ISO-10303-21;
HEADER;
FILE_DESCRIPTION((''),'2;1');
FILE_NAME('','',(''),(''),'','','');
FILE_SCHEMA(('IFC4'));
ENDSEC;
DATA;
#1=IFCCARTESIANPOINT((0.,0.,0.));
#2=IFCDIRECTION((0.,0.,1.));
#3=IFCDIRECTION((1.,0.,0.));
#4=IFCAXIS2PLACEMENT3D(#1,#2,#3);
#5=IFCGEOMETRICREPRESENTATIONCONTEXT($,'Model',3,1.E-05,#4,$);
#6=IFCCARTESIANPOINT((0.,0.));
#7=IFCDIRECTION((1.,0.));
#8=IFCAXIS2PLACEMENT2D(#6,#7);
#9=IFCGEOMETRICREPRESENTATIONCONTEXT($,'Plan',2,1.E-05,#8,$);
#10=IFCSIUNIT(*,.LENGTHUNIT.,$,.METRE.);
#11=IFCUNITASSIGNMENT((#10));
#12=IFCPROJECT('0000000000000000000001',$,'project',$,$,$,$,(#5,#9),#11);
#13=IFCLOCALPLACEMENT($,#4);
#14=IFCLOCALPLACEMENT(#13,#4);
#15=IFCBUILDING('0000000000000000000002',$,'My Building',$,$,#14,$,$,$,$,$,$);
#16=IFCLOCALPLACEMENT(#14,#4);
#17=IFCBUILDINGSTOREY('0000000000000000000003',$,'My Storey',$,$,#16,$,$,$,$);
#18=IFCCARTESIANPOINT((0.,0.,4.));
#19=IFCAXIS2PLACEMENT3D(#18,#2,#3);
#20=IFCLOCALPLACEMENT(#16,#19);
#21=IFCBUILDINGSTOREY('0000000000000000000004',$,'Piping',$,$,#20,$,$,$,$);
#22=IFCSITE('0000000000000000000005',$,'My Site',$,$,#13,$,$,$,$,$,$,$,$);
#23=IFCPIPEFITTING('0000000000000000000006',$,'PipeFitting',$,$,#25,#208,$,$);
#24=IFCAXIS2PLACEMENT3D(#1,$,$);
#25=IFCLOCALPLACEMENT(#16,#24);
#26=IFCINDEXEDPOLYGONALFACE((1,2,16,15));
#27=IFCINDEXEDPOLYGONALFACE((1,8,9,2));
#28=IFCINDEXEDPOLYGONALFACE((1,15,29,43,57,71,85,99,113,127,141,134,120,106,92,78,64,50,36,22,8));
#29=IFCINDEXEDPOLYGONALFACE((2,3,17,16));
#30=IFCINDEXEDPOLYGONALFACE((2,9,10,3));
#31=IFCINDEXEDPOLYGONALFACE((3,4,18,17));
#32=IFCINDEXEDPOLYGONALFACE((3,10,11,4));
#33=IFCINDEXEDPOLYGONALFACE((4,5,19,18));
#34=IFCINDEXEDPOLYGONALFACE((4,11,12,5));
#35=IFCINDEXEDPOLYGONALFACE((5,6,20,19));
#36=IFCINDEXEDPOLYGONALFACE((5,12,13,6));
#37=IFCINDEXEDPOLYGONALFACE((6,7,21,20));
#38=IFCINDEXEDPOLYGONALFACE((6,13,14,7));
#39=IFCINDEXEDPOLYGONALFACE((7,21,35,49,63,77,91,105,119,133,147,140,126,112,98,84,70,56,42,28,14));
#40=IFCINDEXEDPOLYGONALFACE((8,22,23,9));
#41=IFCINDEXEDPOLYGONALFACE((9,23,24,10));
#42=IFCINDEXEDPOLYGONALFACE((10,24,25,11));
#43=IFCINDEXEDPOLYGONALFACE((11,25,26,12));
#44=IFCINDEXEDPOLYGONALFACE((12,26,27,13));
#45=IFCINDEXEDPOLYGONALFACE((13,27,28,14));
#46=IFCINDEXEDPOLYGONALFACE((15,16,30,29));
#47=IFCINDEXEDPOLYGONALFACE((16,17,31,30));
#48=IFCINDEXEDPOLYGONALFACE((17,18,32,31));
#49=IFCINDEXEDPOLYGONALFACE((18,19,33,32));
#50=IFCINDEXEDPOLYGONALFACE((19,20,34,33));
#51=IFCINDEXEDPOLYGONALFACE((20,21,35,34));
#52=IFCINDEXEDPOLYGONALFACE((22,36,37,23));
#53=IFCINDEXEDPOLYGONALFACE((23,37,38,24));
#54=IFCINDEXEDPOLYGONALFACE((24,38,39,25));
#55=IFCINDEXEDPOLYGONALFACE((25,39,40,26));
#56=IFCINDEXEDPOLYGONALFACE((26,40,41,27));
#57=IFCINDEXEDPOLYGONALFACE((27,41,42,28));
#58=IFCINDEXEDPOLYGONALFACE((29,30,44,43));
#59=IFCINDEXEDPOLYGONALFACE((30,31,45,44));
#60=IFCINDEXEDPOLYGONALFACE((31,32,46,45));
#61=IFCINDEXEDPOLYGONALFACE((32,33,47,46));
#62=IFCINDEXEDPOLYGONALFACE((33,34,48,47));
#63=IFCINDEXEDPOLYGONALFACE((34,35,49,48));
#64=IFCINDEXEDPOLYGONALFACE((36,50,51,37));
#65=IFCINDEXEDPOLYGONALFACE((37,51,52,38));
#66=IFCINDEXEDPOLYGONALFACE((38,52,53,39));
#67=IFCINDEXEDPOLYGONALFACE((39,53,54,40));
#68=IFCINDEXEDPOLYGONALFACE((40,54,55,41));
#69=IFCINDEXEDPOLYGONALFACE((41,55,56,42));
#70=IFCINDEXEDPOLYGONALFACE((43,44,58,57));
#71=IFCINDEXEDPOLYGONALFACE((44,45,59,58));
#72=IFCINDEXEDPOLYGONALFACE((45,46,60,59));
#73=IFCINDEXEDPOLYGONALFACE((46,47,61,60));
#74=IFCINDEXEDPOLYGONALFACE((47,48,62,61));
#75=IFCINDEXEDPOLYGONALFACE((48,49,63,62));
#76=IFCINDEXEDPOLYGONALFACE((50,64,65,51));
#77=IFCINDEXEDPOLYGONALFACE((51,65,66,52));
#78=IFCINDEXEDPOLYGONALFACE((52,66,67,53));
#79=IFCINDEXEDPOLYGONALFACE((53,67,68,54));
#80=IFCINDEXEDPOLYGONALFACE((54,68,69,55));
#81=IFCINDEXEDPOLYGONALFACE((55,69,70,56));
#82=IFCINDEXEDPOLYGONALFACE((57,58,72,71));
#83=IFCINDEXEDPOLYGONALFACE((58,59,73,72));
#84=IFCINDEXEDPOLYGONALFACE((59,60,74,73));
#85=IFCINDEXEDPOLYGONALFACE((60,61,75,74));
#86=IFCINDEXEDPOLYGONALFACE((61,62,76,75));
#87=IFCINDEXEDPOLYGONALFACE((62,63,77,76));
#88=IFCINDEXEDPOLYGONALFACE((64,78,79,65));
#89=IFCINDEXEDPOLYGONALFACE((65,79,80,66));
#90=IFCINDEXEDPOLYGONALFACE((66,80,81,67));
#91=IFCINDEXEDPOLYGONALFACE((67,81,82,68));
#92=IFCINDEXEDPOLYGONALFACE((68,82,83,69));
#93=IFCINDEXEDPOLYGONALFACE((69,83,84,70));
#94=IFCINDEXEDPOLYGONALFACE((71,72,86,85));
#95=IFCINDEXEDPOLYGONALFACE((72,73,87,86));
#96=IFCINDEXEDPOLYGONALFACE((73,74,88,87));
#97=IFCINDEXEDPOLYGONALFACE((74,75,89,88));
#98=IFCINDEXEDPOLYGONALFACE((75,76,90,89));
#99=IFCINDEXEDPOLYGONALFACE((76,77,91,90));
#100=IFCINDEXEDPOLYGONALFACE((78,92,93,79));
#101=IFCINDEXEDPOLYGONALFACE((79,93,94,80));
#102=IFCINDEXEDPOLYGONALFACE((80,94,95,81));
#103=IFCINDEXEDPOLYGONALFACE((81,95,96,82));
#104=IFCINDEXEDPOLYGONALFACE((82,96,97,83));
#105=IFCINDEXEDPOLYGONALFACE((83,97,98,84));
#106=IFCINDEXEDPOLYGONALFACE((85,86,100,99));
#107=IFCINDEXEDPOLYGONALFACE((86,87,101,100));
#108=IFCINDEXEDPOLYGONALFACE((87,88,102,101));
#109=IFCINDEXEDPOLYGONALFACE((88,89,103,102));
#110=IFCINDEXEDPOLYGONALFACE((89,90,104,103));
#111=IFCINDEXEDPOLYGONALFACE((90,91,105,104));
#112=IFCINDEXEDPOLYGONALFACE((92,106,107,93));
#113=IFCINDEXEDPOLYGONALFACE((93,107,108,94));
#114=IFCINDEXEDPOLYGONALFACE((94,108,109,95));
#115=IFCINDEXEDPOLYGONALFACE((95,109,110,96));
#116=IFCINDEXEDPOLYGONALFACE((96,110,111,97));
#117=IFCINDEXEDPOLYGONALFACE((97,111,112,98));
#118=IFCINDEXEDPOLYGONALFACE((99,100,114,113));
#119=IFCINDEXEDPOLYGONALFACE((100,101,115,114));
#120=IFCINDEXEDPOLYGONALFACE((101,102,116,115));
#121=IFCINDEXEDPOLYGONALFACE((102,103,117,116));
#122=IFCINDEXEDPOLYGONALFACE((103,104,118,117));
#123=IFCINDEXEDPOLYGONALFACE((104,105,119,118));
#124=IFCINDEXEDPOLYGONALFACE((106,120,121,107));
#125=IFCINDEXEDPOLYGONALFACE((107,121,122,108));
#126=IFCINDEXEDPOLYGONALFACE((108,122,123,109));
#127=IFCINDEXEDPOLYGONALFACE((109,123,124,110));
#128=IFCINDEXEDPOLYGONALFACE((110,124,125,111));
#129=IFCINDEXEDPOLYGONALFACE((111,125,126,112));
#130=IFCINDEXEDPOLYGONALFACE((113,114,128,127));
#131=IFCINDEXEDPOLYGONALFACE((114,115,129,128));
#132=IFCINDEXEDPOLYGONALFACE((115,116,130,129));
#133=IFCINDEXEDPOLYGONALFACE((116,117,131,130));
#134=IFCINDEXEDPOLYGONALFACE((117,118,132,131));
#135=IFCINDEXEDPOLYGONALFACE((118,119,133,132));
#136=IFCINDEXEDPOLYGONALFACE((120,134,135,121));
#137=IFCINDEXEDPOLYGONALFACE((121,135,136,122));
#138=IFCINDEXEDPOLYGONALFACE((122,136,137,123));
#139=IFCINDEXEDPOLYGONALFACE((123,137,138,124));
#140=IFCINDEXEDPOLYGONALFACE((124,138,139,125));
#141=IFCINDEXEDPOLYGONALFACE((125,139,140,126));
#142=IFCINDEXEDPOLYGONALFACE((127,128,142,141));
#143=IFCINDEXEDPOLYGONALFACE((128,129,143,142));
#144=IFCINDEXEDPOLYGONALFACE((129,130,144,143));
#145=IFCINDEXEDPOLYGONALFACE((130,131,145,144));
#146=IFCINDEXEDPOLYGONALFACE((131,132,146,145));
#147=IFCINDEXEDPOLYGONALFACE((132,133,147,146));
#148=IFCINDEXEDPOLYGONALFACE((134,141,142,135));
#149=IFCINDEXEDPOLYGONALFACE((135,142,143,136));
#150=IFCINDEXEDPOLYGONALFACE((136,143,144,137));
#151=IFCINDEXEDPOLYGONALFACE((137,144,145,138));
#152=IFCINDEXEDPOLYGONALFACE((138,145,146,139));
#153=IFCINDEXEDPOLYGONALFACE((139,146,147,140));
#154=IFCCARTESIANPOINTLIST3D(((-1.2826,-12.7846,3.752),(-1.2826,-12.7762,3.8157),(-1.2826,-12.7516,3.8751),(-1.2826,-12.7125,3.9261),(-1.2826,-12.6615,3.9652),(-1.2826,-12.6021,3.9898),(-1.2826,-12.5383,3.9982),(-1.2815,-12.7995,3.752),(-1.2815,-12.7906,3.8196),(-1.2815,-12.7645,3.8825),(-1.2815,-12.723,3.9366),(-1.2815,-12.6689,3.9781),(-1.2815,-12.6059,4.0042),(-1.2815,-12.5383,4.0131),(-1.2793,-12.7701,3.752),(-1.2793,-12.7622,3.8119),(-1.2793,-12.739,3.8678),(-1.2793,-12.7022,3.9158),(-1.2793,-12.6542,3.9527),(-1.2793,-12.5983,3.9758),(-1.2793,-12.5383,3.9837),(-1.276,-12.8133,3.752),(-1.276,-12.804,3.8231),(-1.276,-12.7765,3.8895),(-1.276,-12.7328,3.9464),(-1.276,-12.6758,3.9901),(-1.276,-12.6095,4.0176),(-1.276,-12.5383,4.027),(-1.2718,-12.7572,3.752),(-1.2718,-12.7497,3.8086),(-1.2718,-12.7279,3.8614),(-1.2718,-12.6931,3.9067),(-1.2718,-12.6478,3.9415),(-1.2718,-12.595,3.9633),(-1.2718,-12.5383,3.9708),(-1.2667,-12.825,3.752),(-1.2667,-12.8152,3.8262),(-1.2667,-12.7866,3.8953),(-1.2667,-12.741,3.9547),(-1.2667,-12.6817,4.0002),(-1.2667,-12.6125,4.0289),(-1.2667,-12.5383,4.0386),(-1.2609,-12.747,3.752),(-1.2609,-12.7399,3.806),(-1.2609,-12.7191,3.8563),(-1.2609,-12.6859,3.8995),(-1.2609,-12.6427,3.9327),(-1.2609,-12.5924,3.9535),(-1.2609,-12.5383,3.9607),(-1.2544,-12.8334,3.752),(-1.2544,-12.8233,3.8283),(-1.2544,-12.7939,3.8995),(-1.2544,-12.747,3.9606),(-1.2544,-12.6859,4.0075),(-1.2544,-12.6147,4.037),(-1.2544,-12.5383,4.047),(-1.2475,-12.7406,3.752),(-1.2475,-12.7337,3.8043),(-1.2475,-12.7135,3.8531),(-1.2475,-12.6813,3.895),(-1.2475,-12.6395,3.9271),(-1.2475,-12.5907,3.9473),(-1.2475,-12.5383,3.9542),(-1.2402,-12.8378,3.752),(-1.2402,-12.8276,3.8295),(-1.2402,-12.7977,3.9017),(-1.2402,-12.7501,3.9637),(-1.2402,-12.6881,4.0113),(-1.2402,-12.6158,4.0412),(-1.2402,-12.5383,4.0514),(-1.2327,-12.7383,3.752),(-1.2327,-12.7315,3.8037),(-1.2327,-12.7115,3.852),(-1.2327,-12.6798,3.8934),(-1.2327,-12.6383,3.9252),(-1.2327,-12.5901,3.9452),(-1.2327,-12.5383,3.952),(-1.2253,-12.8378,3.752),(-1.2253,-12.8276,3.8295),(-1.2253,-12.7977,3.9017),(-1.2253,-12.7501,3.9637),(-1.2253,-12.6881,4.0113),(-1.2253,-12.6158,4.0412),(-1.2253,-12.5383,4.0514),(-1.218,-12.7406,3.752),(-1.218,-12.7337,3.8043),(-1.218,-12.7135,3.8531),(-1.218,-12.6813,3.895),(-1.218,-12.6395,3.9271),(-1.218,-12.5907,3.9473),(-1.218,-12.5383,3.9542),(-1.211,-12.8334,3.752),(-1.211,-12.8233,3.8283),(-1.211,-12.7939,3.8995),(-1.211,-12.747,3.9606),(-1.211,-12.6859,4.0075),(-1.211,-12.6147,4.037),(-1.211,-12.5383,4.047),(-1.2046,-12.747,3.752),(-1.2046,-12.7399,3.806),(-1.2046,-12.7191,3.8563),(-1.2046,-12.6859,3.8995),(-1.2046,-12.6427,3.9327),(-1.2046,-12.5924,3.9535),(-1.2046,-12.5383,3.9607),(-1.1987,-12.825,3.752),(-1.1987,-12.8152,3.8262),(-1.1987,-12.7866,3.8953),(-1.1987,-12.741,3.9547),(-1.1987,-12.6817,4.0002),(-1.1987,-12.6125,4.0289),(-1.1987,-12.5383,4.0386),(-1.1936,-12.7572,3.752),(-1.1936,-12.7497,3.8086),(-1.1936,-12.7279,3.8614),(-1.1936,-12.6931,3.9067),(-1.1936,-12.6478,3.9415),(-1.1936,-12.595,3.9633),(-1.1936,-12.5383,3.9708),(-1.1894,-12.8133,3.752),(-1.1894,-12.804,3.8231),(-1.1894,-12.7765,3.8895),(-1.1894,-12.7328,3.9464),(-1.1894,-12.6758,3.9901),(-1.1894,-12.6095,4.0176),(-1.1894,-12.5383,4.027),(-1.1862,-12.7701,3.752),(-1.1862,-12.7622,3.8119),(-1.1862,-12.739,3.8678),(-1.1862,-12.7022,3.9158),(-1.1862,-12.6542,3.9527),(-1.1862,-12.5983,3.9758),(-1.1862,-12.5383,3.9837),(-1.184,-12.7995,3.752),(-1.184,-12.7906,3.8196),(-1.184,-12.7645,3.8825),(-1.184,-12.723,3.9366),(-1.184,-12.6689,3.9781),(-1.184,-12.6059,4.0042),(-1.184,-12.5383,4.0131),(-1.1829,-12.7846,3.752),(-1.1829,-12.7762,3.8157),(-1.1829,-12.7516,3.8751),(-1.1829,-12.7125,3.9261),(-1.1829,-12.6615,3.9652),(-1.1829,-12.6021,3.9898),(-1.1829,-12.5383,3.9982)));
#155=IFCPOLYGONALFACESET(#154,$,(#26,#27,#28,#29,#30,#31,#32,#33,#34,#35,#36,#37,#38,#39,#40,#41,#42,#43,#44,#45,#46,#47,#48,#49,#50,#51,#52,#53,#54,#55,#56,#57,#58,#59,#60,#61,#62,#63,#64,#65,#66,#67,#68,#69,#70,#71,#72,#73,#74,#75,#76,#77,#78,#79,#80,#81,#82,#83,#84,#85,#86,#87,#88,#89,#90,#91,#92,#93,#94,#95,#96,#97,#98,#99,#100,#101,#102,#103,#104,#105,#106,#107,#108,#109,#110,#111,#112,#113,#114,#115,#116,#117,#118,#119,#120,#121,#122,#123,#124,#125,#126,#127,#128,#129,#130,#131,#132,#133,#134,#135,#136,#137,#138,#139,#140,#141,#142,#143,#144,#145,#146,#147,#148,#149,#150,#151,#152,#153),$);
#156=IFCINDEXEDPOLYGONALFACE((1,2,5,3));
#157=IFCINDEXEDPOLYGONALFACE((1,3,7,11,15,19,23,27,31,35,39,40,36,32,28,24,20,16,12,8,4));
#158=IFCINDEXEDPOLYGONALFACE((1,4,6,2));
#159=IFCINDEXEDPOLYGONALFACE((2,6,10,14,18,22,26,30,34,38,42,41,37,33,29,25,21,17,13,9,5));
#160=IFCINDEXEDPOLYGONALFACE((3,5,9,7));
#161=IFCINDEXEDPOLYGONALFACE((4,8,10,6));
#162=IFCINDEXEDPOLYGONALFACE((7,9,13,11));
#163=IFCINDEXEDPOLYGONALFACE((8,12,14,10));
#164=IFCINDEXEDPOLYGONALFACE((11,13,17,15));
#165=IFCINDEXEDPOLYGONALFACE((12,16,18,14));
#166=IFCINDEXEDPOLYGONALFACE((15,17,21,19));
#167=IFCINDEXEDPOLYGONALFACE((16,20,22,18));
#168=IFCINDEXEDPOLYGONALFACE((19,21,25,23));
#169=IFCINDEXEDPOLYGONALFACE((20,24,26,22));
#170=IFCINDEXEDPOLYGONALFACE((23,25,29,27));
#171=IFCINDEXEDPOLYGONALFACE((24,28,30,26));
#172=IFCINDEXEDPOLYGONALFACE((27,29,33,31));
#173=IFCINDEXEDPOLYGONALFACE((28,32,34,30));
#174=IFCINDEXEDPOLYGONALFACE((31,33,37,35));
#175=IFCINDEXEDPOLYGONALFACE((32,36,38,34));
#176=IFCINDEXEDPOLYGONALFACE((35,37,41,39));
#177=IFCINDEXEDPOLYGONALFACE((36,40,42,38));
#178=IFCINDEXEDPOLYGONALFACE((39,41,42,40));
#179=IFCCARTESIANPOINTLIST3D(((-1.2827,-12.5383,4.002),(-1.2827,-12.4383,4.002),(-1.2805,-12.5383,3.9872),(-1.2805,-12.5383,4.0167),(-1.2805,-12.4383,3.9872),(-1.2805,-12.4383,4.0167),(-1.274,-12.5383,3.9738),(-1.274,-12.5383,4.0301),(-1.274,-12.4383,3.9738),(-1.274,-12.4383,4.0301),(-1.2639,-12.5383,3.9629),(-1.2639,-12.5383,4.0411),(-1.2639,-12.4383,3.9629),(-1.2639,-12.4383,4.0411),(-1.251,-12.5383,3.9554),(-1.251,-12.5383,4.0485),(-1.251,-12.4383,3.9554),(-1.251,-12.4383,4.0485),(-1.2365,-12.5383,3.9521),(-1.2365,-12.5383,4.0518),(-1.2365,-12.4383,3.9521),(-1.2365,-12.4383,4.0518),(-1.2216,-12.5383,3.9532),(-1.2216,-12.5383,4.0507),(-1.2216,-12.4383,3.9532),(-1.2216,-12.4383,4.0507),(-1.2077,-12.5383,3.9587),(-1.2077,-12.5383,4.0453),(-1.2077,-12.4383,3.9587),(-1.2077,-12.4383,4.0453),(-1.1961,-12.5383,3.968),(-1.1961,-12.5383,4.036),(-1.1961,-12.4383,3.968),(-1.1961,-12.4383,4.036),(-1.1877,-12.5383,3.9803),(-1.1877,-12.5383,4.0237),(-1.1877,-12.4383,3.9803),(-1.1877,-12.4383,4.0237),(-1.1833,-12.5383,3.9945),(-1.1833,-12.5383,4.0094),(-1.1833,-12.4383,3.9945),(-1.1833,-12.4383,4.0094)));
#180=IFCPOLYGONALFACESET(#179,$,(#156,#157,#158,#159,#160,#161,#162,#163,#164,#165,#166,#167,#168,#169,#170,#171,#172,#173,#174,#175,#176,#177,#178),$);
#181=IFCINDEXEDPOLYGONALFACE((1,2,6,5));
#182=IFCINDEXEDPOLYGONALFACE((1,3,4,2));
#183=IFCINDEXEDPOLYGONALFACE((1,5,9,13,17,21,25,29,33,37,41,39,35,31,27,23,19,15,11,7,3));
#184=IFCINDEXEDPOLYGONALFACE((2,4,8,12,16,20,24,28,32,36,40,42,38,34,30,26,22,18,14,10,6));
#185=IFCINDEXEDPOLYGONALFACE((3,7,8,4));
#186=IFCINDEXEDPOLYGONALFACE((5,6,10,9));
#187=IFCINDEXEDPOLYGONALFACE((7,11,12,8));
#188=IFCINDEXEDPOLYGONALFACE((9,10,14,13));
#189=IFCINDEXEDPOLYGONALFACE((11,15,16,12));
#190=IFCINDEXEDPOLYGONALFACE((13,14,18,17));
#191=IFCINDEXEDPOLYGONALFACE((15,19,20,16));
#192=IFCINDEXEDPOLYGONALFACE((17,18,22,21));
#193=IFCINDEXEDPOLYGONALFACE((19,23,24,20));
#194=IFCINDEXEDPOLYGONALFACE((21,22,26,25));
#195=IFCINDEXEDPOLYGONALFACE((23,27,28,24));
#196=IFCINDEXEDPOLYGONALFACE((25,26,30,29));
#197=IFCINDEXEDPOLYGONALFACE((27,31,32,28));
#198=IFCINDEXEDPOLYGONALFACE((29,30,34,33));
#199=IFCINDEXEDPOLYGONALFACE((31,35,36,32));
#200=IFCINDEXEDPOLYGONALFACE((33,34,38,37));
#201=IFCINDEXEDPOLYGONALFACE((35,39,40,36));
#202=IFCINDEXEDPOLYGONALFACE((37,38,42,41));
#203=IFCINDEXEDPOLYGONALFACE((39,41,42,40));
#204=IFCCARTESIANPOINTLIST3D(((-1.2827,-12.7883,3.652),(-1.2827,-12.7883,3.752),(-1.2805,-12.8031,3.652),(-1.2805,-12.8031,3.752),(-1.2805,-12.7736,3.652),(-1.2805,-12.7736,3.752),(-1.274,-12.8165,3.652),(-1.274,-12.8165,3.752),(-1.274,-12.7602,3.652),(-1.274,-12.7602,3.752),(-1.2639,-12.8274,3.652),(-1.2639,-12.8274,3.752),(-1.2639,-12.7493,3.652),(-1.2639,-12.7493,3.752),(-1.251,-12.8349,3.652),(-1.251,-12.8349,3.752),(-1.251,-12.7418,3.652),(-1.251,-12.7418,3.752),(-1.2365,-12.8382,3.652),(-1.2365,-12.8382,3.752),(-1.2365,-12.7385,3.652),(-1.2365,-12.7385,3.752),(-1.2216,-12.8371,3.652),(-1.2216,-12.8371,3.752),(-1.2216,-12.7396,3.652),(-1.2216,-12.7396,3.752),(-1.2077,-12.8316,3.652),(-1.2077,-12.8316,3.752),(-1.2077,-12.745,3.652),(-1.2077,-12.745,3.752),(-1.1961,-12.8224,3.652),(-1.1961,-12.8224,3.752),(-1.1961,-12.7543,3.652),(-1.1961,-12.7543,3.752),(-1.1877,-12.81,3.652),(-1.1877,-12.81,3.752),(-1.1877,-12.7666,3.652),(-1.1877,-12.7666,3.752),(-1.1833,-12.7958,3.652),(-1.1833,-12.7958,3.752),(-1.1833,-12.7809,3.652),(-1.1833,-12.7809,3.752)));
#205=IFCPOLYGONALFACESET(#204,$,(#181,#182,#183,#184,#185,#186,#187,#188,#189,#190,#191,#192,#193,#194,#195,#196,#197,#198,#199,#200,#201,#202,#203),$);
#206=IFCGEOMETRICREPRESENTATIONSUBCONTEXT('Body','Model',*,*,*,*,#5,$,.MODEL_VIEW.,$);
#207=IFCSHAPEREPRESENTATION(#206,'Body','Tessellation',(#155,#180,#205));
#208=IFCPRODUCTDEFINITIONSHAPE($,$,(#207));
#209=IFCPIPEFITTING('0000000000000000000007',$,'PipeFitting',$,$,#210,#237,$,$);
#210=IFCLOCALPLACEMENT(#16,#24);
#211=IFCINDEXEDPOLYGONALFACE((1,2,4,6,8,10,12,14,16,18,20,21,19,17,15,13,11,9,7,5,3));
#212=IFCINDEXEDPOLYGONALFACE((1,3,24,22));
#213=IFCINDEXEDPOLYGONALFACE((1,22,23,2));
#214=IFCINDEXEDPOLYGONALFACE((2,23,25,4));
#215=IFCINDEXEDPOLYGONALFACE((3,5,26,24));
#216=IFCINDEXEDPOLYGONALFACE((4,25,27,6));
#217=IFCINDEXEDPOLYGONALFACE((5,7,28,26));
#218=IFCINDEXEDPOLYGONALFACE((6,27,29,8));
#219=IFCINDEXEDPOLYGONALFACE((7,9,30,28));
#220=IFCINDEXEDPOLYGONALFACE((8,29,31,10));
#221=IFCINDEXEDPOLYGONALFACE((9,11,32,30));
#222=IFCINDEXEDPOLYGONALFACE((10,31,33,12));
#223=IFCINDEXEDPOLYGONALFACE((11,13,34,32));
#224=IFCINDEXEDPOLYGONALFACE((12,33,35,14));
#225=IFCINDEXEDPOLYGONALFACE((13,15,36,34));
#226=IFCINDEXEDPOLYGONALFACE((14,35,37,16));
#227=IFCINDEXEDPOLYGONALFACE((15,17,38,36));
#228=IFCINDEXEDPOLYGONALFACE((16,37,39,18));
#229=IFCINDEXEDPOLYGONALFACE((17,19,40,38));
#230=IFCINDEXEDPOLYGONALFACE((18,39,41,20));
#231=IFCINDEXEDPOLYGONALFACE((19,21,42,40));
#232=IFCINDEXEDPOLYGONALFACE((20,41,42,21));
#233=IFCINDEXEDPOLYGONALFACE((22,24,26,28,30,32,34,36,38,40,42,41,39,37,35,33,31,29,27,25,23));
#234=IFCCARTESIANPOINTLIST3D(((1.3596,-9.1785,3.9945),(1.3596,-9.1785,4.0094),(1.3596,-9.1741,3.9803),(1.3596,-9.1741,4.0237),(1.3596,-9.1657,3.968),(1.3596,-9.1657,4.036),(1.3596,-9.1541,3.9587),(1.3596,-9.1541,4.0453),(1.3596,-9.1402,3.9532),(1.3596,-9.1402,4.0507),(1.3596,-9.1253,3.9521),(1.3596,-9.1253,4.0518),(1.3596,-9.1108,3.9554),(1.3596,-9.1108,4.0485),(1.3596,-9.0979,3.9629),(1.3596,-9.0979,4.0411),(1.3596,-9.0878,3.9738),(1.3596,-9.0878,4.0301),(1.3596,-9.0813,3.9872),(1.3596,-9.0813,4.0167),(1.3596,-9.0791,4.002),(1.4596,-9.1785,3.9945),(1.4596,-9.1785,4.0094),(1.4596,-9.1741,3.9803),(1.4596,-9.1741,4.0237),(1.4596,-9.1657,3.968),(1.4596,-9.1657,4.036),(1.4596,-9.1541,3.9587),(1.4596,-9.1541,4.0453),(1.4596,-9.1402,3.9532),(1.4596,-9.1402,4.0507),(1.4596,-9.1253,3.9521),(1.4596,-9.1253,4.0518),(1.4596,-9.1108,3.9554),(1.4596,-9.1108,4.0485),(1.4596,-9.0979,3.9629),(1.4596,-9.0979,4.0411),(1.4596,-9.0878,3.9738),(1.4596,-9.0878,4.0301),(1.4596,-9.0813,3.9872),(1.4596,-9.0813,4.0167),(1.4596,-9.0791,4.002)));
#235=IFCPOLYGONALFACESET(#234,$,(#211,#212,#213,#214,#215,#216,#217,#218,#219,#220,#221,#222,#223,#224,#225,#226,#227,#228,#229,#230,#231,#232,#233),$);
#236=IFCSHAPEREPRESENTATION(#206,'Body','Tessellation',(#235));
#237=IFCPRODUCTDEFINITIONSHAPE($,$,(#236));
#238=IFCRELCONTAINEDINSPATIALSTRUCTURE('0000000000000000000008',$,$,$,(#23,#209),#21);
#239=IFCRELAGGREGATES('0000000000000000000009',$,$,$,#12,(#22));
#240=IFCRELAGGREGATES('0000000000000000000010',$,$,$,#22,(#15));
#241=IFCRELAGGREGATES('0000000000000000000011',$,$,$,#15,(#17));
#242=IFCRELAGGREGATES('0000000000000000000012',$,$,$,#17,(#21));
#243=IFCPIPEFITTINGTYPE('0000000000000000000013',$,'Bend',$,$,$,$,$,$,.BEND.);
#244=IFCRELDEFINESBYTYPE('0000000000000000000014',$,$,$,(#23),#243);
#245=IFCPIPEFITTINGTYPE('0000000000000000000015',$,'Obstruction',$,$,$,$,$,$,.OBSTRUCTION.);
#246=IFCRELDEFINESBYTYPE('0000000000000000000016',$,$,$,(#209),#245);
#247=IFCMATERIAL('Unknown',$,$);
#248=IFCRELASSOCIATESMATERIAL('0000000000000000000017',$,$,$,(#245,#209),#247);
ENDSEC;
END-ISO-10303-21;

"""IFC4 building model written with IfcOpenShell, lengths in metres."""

from ifc_helpers import new_model, entity, si_unit, frame, origin_with_axes, origin_2d_with_axis, place, context, subcontext, project, spatial, circle, extrude, source, transform, mapped, material, material_profile, profile_set, profile_usage, type_object, type_shapes, element, save


model = new_model("IFC4")

# Units and contexts
model_context = context("Model", 3, precision=1e-05, world=origin_with_axes())
plan_context = context("Plan", 2, precision=1e-05, world=origin_2d_with_axis())
body_context = subcontext(model_context, "Body", "Model", "MODEL_VIEW")
ifc_project = project(units=[si_unit("LENGTHUNIT", "METRE")], contexts=[model_context, plan_context])

# Site, building, storeys
site_placement = place(None, origin_with_axes())
site = spatial("IfcSite", under=ifc_project, at=site_placement, Name="My Site")
building_placement = place(site_placement, origin_with_axes())
building = spatial("IfcBuilding", under=site, at=building_placement, Name="My Building")
storey_1_placement = place(building_placement, origin_with_axes())
storey_1 = spatial("IfcBuildingStorey", under=building, at=storey_1_placement, Name="My Storey")
storey_2_placement = place(storey_1_placement, frame((0.0, 0.0, 4.0), z_axis=(0.0, 0.0, 1.0), x_axis=(1.0, 0.0, 0.0)))
storey_2 = spatial("IfcBuildingStorey", under=storey_1, at=storey_2_placement, Name="Piping")

# Shared definitions
ifc_material = material(Name="Unknown")

# Shared definitions
pipe_fitting_type_1 = type_object("IfcPipeFittingType", Name="Bend", PredefinedType="BEND")
shared_shape = source(origin_with_axes(), body_context, "Body", "SolidModel", [
    entity("IfcSweptDiskSolid", entity("IfcIndexedPolyCurve", entity("IfcCartesianPointList3D", [[0.0, 0.0, -0.1], [0.0, -0.0732, -0.2768], [0.0, -0.25, -0.35]]), [entity("IfcArcIndex", [1, 2, 3])]), 0.05),
    extrude(circle(Radius=0.05), origin_with_axes(), (0.0, 0.0, -1.0), 0.1),
    extrude(circle(Radius=0.05), frame((0.0, -0.25, -0.35), z_axis=(0.0, -1.0, 0.0), x_axis=(1.0, 0.0, 0.0)), (0.0, 0.0, 1.0), 0.1),
])
type_shapes(pipe_fitting_type_1, [shared_shape])

# Pipe fittings
pipe_fitting_1_placement = place(storey_2_placement, frame((-1.2327, -12.4383, 0.002), z_axis=(0.0, 1.0, 0.000001), x_axis=(-1.0, 0.0, 0.0)))
element("IfcPipeFitting", 1, at=pipe_fitting_1_placement, inside=storey_2, type_object=pipe_fitting_type_1, Name="PipeFitting", context=body_context, shape_type="MappedRepresentation", body=[
    mapped(shared_shape, transform((0.0, 0.0, 0.0), x_axis=(1.0, 0.0, 0.0), y_axis=(0.0, 1.0, 0.0), z_axis=(0.0, 0.0, 1.0), scale=1.0)),
])
ifc_material_profile_1 = material_profile(ifc_material, circle(Radius=0.05))
ifc_profile_set_1 = profile_set([ifc_material_profile_1])
ifc_profile_usage_1 = profile_usage(ifc_profile_set_1, cardinal=5)
pipe_fitting_type_2 = type_object("IfcPipeFittingType", Name="Obstruction", PredefinedType="OBSTRUCTION", material=ifc_profile_set_1)
pipe_fitting_2_placement = place(storey_2_placement, frame((1.3596, -9.1291, 0.002), z_axis=(1.0, 0.0, 0.0), x_axis=(0.0, 1.0, 0.0)))
element("IfcPipeFitting", 2, at=pipe_fitting_2_placement, inside=storey_2, type_object=pipe_fitting_type_2, material=ifc_profile_usage_1, Name="PipeFitting", context=body_context, shape_type="SweptSolid", body=[
    extrude(circle(Radius=0.05), origin_with_axes(), (0.0, 0.0, 1.0), 0.1),
])

save(model, "model.ifc")
